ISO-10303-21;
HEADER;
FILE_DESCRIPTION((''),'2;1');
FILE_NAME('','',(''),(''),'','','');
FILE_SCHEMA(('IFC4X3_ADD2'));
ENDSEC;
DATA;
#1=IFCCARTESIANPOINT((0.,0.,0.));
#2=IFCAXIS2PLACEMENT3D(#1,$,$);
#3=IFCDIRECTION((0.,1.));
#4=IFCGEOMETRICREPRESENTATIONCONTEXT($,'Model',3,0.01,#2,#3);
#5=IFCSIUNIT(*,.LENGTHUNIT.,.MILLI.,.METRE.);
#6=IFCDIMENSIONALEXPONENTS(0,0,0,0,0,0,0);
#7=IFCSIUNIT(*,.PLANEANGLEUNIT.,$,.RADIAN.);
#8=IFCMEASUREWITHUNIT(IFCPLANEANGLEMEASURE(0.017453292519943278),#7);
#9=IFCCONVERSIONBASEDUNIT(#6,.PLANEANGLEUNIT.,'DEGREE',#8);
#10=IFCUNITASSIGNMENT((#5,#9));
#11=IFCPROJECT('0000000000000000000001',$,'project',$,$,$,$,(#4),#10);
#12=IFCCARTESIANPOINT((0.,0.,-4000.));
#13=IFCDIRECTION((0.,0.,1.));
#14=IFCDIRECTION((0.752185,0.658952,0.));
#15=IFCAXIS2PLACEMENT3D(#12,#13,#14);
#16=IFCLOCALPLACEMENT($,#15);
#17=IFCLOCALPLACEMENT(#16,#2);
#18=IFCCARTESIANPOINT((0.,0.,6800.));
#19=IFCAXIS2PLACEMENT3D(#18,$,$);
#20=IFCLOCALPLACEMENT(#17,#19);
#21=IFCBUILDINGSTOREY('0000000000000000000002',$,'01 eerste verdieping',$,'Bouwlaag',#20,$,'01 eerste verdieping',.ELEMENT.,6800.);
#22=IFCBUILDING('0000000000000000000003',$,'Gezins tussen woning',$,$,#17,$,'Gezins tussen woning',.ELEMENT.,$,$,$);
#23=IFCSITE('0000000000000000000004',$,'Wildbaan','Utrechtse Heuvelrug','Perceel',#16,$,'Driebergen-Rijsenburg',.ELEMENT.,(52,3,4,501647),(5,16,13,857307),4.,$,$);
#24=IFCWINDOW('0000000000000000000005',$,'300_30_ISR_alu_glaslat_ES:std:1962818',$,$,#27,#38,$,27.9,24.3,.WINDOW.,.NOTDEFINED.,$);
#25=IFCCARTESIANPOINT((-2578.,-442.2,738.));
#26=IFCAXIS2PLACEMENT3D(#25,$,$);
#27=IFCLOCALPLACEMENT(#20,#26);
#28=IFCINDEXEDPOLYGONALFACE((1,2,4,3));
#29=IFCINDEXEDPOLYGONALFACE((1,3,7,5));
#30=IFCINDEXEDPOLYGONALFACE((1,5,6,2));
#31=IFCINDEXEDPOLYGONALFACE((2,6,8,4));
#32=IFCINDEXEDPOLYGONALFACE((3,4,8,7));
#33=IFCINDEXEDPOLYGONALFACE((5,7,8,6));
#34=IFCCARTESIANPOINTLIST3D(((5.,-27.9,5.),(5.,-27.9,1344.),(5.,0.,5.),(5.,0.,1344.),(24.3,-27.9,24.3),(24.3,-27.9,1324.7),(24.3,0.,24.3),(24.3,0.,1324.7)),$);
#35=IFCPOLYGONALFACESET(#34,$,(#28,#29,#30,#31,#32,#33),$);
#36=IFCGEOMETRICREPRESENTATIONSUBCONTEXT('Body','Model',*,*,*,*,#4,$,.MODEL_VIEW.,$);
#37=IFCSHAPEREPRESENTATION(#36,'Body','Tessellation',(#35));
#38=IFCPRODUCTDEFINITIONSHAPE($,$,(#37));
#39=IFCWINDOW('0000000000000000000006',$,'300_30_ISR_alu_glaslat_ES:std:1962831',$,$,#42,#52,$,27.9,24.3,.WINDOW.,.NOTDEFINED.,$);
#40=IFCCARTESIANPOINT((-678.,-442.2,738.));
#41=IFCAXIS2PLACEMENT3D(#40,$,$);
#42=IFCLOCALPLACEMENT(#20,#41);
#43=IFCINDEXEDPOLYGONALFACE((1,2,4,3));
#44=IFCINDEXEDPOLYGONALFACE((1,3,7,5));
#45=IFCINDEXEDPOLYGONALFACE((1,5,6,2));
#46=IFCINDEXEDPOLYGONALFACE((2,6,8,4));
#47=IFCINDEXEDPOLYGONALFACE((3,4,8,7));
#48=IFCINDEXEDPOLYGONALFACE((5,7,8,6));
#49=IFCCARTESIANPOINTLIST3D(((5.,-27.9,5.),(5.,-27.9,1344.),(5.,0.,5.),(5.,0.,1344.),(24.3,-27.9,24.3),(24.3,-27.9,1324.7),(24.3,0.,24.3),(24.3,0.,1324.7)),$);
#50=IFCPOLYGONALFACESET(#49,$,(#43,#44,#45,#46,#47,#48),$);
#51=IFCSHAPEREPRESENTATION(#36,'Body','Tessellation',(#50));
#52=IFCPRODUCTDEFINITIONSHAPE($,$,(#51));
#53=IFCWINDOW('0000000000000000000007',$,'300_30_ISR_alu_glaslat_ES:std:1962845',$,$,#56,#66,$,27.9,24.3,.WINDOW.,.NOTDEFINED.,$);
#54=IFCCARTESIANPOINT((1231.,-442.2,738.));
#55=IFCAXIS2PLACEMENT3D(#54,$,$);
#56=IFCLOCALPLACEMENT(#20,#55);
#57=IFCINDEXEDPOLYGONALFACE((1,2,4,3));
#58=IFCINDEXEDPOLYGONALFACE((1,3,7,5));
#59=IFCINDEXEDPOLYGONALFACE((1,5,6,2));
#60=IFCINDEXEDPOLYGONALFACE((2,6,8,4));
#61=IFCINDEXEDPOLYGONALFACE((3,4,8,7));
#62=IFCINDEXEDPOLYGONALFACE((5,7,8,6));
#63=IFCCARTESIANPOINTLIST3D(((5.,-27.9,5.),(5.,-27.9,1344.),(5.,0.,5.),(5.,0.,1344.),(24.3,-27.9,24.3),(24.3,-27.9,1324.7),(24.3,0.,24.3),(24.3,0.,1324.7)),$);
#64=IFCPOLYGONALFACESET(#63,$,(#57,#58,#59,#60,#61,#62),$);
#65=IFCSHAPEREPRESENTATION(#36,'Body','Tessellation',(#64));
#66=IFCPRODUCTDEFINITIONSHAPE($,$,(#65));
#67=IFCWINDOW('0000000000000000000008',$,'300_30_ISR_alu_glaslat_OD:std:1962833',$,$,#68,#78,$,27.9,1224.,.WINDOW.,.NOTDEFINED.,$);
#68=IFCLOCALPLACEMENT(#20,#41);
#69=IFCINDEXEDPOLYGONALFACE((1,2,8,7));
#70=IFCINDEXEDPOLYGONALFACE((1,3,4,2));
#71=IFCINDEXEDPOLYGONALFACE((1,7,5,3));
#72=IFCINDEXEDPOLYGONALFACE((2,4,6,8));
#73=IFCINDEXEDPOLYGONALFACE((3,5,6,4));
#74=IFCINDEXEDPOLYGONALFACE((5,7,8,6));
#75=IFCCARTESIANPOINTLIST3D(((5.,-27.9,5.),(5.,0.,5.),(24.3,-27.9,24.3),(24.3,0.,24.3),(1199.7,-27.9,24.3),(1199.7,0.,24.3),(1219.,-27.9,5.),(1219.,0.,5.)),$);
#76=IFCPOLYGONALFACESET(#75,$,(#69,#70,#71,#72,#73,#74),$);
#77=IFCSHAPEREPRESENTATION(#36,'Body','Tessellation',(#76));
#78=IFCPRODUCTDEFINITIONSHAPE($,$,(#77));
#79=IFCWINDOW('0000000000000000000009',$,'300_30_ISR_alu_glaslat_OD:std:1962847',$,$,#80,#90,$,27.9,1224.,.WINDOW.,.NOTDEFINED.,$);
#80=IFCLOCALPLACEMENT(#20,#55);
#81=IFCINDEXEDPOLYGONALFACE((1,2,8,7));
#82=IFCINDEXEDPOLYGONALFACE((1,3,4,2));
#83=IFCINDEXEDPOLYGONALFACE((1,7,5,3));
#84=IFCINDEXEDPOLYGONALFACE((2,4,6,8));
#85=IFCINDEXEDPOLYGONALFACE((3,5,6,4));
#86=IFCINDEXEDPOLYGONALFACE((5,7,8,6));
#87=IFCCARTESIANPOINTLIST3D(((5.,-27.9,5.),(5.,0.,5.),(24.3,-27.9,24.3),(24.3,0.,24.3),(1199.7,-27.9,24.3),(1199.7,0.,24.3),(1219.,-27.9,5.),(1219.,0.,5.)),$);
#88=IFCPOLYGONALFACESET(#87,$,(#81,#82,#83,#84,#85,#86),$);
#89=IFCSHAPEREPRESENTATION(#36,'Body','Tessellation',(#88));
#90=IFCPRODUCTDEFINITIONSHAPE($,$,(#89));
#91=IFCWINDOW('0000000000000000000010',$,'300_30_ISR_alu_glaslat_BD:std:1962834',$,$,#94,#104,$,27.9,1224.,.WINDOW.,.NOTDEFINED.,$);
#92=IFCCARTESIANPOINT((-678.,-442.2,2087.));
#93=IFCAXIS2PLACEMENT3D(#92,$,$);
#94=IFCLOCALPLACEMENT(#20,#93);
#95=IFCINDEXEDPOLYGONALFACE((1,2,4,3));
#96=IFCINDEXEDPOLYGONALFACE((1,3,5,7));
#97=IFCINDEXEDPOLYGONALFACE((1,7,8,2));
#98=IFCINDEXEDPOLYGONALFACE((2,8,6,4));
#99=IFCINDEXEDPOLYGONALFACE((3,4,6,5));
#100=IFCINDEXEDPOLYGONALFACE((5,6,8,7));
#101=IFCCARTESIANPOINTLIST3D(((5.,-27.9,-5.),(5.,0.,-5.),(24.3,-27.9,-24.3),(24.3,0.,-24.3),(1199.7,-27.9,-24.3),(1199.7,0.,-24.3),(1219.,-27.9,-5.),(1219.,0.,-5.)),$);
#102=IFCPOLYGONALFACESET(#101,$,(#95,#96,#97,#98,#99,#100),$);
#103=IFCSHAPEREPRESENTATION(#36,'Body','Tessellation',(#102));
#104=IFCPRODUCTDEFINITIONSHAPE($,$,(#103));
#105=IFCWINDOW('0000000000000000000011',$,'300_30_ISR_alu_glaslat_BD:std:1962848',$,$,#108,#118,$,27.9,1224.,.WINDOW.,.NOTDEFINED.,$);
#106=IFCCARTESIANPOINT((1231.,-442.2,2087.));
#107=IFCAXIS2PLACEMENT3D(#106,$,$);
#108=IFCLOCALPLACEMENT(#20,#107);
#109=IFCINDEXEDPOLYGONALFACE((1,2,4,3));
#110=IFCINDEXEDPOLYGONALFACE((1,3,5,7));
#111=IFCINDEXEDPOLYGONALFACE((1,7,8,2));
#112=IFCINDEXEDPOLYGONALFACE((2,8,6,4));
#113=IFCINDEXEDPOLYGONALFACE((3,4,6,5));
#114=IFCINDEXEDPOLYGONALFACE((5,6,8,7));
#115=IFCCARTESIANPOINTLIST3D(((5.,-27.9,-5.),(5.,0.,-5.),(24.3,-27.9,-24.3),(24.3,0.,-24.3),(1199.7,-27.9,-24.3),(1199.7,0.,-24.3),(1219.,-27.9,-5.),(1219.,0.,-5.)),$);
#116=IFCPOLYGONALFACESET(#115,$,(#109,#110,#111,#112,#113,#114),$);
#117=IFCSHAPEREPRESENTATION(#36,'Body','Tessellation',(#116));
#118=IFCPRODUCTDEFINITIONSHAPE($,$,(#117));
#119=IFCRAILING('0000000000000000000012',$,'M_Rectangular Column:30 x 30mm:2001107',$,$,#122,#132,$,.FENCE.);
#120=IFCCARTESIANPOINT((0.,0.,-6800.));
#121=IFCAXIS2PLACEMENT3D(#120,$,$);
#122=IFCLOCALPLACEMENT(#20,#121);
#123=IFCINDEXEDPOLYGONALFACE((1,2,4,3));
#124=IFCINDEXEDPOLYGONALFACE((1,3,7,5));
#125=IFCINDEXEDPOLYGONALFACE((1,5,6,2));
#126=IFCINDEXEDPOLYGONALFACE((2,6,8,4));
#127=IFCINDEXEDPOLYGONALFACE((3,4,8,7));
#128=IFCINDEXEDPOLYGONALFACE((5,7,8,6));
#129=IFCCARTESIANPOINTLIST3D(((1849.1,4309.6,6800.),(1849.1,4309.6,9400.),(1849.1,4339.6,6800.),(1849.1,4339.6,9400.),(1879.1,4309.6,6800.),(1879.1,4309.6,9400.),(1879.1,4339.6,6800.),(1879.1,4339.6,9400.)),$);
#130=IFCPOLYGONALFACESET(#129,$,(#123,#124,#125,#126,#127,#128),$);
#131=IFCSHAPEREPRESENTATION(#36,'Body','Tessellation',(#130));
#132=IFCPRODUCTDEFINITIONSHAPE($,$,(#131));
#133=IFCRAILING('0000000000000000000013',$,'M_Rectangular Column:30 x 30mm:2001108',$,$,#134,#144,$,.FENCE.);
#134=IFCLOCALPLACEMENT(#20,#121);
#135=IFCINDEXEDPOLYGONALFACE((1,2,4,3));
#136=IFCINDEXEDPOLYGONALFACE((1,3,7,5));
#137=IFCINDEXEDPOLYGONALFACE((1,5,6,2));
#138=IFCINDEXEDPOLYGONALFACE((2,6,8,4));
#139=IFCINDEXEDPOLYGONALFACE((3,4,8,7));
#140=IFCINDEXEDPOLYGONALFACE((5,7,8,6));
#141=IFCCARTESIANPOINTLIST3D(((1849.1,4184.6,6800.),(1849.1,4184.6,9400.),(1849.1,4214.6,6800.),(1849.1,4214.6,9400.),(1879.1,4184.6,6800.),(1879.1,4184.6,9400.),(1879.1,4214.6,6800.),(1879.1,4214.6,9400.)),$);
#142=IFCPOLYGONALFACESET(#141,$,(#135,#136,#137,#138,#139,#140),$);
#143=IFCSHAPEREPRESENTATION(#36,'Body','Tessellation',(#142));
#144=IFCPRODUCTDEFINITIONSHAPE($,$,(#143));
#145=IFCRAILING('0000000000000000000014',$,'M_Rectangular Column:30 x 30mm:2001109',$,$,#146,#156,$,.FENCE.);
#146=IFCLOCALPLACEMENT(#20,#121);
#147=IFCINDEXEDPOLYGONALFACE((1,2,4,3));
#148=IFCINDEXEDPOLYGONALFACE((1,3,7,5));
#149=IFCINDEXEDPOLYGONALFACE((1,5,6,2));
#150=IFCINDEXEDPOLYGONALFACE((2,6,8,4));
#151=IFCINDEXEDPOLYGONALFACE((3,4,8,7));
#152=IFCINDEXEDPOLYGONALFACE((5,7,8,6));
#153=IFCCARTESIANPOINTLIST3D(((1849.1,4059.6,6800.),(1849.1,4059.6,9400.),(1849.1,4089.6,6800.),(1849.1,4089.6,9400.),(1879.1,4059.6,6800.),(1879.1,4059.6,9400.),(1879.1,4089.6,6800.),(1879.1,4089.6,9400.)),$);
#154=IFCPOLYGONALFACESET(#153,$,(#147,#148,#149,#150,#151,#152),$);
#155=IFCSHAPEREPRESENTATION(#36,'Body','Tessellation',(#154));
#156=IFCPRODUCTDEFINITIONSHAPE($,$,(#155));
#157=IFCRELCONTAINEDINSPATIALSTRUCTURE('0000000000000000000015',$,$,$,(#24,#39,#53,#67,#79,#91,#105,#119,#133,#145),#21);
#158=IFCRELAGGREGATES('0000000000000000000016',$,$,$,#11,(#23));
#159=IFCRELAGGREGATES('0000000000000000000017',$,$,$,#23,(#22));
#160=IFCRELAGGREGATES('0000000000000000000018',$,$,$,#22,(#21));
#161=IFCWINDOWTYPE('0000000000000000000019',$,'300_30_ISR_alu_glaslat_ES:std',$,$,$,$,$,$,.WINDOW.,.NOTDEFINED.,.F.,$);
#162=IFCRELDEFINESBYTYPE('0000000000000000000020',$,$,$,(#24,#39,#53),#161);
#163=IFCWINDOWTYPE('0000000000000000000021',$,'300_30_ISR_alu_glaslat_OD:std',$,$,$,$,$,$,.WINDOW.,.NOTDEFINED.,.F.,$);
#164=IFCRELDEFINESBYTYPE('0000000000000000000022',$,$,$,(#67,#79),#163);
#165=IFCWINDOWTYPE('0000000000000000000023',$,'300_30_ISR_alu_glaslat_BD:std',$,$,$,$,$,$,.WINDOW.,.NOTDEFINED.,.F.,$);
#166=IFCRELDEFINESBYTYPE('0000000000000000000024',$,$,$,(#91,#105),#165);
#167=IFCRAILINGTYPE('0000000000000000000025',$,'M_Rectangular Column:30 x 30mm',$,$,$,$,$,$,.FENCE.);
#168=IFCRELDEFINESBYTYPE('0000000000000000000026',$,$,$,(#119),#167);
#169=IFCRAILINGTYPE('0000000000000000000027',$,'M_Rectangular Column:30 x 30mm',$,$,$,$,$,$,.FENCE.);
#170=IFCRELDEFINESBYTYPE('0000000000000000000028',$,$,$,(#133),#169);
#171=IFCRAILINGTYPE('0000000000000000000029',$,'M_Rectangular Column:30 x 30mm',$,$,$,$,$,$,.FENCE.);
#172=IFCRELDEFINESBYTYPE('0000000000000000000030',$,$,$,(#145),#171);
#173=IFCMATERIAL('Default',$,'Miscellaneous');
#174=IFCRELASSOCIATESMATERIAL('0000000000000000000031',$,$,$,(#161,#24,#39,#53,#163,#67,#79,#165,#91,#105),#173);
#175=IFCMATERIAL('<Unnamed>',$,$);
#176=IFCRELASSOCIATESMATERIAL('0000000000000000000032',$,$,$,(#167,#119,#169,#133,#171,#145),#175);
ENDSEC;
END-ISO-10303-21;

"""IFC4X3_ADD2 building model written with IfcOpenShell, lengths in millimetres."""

from ifc_helpers import new_model, entity, si_unit, converted_unit, direction, frame, frame_2d, origin, place, context, subcontext, project, spatial, polyline, rectangle, outline, extrude, source, transform, mapped, material, type_object, type_shapes, element, save


model = new_model("IFC4X3_ADD2")

# Units and contexts
model_context = context("Model", 3, precision=0.01, world=origin(), true_north=direction((0.0, 1.0)))
body_context = subcontext(model_context, "Body", "Model", "MODEL_VIEW")
ifc_project = project(units=[si_unit("LENGTHUNIT", "METRE", prefix="MILLI"), converted_unit("PLANEANGLEUNIT", "DEGREE", entity("IfcPlaneAngleMeasure", 0.017453292519943278), si_unit("PLANEANGLEUNIT", "RADIAN"), dimensions=[0, 0, 0, 0, 0, 0, 0])], contexts=[model_context])

# Site, building, storey
site_placement = place(None, frame((0.0, 0.0, -4000.0), z_axis=(0.0, 0.0, 1.0), x_axis=(0.752185, 0.658952, 0.0)))
site = spatial("IfcSite", under=ifc_project, at=site_placement, Name="Wildbaan", Description="Utrechtse Heuvelrug", ObjectType="Perceel", LongName="Driebergen-Rijsenburg", CompositionType="ELEMENT", RefLatitude=(52, 3, 4, 501647), RefLongitude=(5, 16, 13, 857307), RefElevation=4.0)
building_placement = place(site_placement, origin())
building = spatial("IfcBuilding", under=site, at=building_placement, Name="Gezins tussen woning", LongName="Gezins tussen woning", CompositionType="ELEMENT")
storey_placement = place(building_placement, frame((0.0, 0.0, 6800.0)))
storey = spatial("IfcBuildingStorey", under=building, at=storey_placement, Name="01 eerste verdieping", ObjectType="Bouwlaag", LongName="01 eerste verdieping", CompositionType="ELEMENT", Elevation=6800.0)

# Windows
ifc_material_1 = material(Name="Default", Category="Miscellaneous")
window_type_1 = type_object("IfcWindowType", Name="300_30_ISR_alu_glaslat_ES:std", ParameterTakesPrecedence=False, PartitioningType="NOTDEFINED", PredefinedType="WINDOW", material=ifc_material_1)
shared_shape_1 = source(origin(), body_context, "Body", "SweptSolid", [
    extrude(outline(polyline([(-650.2, -9.6), (650.2, -9.6), (669.5, 9.6), (-669.5, 9.6), (-650.2, -9.6)])), frame((14.6, -27.9, 674.5), z_axis=(0.0, 1.0, 0.0), x_axis=(0.0, 0.0, -1.0)), (0.0, 0.0, 1.0), 27.9),
])
type_shapes(window_type_1, [shared_shape_1])
for number, where, name in (
    (1, (-2578.0, -442.2, 738.0), "300_30_ISR_alu_glaslat_ES:std:1962818"),
    (2, (-678.0, -442.2, 738.0), "300_30_ISR_alu_glaslat_ES:std:1962831"),
    (3, (1231.0, -442.2, 738.0), "300_30_ISR_alu_glaslat_ES:std:1962845"),
):
    element("IfcWindow", number, at=place(storey_placement, frame(where)), inside=storey, type_object=window_type_1, material=ifc_material_1, Name=name, OverallHeight=27.9, OverallWidth=24.3, PartitioningType="NOTDEFINED", PredefinedType="WINDOW", context=body_context, shape_type="MappedRepresentation", body=[
        mapped(shared_shape_1, transform((0.0, 0.0, 0.0), scale=1.0)),
    ])
window_type_2 = type_object("IfcWindowType", Name="300_30_ISR_alu_glaslat_OD:std", ParameterTakesPrecedence=False, PartitioningType="NOTDEFINED", PredefinedType="WINDOW", material=ifc_material_1)
shared_shape_2 = source(origin(), body_context, "Body", "SweptSolid", [
    extrude(outline(polyline([(-587.7, -9.7), (587.7, -9.7), (607.0, 9.7), (-607.0, 9.6), (-587.7, -9.7)])), frame((612.0, -27.9, 14.6), z_axis=(0.0, 1.0, 0.0), x_axis=(1.0, 0.0, 0.0)), (0.0, 0.0, 1.0), 27.9),
])
type_shapes(window_type_2, [shared_shape_2])
for number, where, name in (
    (4, (-678.0, -442.2, 738.0), "300_30_ISR_alu_glaslat_OD:std:1962833"),
    (5, (1231.0, -442.2, 738.0), "300_30_ISR_alu_glaslat_OD:std:1962847"),
):
    element("IfcWindow", number, at=place(storey_placement, frame(where)), inside=storey, type_object=window_type_2, material=ifc_material_1, Name=name, OverallHeight=27.9, OverallWidth=1224.0, PartitioningType="NOTDEFINED", PredefinedType="WINDOW", context=body_context, shape_type="MappedRepresentation", body=[
        mapped(shared_shape_2, transform((0.0, 0.0, 0.0), scale=1.0)),
    ])
window_type_3 = type_object("IfcWindowType", Name="300_30_ISR_alu_glaslat_BD:std", ParameterTakesPrecedence=False, PartitioningType="NOTDEFINED", PredefinedType="WINDOW", material=ifc_material_1)
shared_shape_3 = source(origin(), body_context, "Body", "SweptSolid", [
    extrude(outline(polyline([(-607.0, -9.6), (607.0, -9.6), (587.7, 9.6), (-587.7, 9.7), (-607.0, -9.6)])), frame((612.0, -27.9, -14.6), z_axis=(0.0, 1.0, 0.0), x_axis=(1.0, 0.0, 0.0)), (0.0, 0.0, 1.0), 27.9),
])
type_shapes(window_type_3, [shared_shape_3])
for number, where, name in (
    (6, (-678.0, -442.2, 2087.0), "300_30_ISR_alu_glaslat_BD:std:1962834"),
    (7, (1231.0, -442.2, 2087.0), "300_30_ISR_alu_glaslat_BD:std:1962848"),
):
    element("IfcWindow", number, at=place(storey_placement, frame(where)), inside=storey, type_object=window_type_3, material=ifc_material_1, Name=name, OverallHeight=27.9, OverallWidth=1224.0, PartitioningType="NOTDEFINED", PredefinedType="WINDOW", context=body_context, shape_type="MappedRepresentation", body=[
        mapped(shared_shape_3, transform((0.0, 0.0, 0.0), scale=1.0)),
    ])

# Shared definitions
ifc_material_2 = material(Name="<Unnamed>")

# Railings
railing_type_1 = type_object("IfcRailingType", Name="M_Rectangular Column:30 x 30mm", PredefinedType="FENCE", material=ifc_material_2)
shared_shape_4 = source(origin(), body_context, "Body", "SweptSolid", [
    extrude(rectangle(XDim=30.0, YDim=30.0, at=frame_2d((0.0, 0.0), x_axis=(1.0, 0.0))), frame((1864.1, 4324.6, 6800.0), z_axis=(0.0, 0.0, 1.0), x_axis=(-1.0, 0.0, 0.0)), (0.0, 0.0, 1.0), 2600.0),
])
type_shapes(railing_type_1, [shared_shape_4])
railing_1_placement = place(storey_placement, frame((0.0, 0.0, -6800.0)))
element("IfcRailing", 8, at=railing_1_placement, inside=storey, type_object=railing_type_1, material=ifc_material_2, Name="M_Rectangular Column:30 x 30mm:2001107", PredefinedType="FENCE", context=body_context, shape_type="MappedRepresentation", body=[
    mapped(shared_shape_4, transform((0.0, 0.0, 0.0), scale=1.0)),
])
railing_type_2 = type_object("IfcRailingType", Name="M_Rectangular Column:30 x 30mm", PredefinedType="FENCE", material=ifc_material_2)
shared_shape_5 = source(origin(), body_context, "Body", "SweptSolid", [
    extrude(rectangle(XDim=30.0, YDim=30.0, at=frame_2d((0.0, 0.0), x_axis=(1.0, 0.0))), frame((1864.1, 4199.6, 6800.0), z_axis=(0.0, 0.0, 1.0), x_axis=(-1.0, 0.0, 0.0)), (0.0, 0.0, 1.0), 2600.0),
])
type_shapes(railing_type_2, [shared_shape_5])
railing_2_placement = place(storey_placement, frame((0.0, 0.0, -6800.0)))
element("IfcRailing", 9, at=railing_2_placement, inside=storey, type_object=railing_type_2, material=ifc_material_2, Name="M_Rectangular Column:30 x 30mm:2001108", PredefinedType="FENCE", context=body_context, shape_type="MappedRepresentation", body=[
    mapped(shared_shape_5, transform((0.0, 0.0, 0.0), scale=1.0)),
])
railing_type_3 = type_object("IfcRailingType", Name="M_Rectangular Column:30 x 30mm", PredefinedType="FENCE", material=ifc_material_2)
shared_shape_6 = source(origin(), body_context, "Body", "SweptSolid", [
    extrude(rectangle(XDim=30.0, YDim=30.0, at=frame_2d((0.0, 0.0), x_axis=(1.0, 0.0))), frame((1864.1, 4074.6, 6800.0), z_axis=(0.0, 0.0, 1.0), x_axis=(-1.0, 0.0, 0.0)), (0.0, 0.0, 1.0), 2600.0),
])
type_shapes(railing_type_3, [shared_shape_6])
railing_3_placement = place(storey_placement, frame((0.0, 0.0, -6800.0)))
element("IfcRailing", 10, at=railing_3_placement, inside=storey, type_object=railing_type_3, material=ifc_material_2, Name="M_Rectangular Column:30 x 30mm:2001109", PredefinedType="FENCE", context=body_context, shape_type="MappedRepresentation", body=[
    mapped(shared_shape_6, transform((0.0, 0.0, 0.0), scale=1.0)),
])

save(model, "model.ifc")
